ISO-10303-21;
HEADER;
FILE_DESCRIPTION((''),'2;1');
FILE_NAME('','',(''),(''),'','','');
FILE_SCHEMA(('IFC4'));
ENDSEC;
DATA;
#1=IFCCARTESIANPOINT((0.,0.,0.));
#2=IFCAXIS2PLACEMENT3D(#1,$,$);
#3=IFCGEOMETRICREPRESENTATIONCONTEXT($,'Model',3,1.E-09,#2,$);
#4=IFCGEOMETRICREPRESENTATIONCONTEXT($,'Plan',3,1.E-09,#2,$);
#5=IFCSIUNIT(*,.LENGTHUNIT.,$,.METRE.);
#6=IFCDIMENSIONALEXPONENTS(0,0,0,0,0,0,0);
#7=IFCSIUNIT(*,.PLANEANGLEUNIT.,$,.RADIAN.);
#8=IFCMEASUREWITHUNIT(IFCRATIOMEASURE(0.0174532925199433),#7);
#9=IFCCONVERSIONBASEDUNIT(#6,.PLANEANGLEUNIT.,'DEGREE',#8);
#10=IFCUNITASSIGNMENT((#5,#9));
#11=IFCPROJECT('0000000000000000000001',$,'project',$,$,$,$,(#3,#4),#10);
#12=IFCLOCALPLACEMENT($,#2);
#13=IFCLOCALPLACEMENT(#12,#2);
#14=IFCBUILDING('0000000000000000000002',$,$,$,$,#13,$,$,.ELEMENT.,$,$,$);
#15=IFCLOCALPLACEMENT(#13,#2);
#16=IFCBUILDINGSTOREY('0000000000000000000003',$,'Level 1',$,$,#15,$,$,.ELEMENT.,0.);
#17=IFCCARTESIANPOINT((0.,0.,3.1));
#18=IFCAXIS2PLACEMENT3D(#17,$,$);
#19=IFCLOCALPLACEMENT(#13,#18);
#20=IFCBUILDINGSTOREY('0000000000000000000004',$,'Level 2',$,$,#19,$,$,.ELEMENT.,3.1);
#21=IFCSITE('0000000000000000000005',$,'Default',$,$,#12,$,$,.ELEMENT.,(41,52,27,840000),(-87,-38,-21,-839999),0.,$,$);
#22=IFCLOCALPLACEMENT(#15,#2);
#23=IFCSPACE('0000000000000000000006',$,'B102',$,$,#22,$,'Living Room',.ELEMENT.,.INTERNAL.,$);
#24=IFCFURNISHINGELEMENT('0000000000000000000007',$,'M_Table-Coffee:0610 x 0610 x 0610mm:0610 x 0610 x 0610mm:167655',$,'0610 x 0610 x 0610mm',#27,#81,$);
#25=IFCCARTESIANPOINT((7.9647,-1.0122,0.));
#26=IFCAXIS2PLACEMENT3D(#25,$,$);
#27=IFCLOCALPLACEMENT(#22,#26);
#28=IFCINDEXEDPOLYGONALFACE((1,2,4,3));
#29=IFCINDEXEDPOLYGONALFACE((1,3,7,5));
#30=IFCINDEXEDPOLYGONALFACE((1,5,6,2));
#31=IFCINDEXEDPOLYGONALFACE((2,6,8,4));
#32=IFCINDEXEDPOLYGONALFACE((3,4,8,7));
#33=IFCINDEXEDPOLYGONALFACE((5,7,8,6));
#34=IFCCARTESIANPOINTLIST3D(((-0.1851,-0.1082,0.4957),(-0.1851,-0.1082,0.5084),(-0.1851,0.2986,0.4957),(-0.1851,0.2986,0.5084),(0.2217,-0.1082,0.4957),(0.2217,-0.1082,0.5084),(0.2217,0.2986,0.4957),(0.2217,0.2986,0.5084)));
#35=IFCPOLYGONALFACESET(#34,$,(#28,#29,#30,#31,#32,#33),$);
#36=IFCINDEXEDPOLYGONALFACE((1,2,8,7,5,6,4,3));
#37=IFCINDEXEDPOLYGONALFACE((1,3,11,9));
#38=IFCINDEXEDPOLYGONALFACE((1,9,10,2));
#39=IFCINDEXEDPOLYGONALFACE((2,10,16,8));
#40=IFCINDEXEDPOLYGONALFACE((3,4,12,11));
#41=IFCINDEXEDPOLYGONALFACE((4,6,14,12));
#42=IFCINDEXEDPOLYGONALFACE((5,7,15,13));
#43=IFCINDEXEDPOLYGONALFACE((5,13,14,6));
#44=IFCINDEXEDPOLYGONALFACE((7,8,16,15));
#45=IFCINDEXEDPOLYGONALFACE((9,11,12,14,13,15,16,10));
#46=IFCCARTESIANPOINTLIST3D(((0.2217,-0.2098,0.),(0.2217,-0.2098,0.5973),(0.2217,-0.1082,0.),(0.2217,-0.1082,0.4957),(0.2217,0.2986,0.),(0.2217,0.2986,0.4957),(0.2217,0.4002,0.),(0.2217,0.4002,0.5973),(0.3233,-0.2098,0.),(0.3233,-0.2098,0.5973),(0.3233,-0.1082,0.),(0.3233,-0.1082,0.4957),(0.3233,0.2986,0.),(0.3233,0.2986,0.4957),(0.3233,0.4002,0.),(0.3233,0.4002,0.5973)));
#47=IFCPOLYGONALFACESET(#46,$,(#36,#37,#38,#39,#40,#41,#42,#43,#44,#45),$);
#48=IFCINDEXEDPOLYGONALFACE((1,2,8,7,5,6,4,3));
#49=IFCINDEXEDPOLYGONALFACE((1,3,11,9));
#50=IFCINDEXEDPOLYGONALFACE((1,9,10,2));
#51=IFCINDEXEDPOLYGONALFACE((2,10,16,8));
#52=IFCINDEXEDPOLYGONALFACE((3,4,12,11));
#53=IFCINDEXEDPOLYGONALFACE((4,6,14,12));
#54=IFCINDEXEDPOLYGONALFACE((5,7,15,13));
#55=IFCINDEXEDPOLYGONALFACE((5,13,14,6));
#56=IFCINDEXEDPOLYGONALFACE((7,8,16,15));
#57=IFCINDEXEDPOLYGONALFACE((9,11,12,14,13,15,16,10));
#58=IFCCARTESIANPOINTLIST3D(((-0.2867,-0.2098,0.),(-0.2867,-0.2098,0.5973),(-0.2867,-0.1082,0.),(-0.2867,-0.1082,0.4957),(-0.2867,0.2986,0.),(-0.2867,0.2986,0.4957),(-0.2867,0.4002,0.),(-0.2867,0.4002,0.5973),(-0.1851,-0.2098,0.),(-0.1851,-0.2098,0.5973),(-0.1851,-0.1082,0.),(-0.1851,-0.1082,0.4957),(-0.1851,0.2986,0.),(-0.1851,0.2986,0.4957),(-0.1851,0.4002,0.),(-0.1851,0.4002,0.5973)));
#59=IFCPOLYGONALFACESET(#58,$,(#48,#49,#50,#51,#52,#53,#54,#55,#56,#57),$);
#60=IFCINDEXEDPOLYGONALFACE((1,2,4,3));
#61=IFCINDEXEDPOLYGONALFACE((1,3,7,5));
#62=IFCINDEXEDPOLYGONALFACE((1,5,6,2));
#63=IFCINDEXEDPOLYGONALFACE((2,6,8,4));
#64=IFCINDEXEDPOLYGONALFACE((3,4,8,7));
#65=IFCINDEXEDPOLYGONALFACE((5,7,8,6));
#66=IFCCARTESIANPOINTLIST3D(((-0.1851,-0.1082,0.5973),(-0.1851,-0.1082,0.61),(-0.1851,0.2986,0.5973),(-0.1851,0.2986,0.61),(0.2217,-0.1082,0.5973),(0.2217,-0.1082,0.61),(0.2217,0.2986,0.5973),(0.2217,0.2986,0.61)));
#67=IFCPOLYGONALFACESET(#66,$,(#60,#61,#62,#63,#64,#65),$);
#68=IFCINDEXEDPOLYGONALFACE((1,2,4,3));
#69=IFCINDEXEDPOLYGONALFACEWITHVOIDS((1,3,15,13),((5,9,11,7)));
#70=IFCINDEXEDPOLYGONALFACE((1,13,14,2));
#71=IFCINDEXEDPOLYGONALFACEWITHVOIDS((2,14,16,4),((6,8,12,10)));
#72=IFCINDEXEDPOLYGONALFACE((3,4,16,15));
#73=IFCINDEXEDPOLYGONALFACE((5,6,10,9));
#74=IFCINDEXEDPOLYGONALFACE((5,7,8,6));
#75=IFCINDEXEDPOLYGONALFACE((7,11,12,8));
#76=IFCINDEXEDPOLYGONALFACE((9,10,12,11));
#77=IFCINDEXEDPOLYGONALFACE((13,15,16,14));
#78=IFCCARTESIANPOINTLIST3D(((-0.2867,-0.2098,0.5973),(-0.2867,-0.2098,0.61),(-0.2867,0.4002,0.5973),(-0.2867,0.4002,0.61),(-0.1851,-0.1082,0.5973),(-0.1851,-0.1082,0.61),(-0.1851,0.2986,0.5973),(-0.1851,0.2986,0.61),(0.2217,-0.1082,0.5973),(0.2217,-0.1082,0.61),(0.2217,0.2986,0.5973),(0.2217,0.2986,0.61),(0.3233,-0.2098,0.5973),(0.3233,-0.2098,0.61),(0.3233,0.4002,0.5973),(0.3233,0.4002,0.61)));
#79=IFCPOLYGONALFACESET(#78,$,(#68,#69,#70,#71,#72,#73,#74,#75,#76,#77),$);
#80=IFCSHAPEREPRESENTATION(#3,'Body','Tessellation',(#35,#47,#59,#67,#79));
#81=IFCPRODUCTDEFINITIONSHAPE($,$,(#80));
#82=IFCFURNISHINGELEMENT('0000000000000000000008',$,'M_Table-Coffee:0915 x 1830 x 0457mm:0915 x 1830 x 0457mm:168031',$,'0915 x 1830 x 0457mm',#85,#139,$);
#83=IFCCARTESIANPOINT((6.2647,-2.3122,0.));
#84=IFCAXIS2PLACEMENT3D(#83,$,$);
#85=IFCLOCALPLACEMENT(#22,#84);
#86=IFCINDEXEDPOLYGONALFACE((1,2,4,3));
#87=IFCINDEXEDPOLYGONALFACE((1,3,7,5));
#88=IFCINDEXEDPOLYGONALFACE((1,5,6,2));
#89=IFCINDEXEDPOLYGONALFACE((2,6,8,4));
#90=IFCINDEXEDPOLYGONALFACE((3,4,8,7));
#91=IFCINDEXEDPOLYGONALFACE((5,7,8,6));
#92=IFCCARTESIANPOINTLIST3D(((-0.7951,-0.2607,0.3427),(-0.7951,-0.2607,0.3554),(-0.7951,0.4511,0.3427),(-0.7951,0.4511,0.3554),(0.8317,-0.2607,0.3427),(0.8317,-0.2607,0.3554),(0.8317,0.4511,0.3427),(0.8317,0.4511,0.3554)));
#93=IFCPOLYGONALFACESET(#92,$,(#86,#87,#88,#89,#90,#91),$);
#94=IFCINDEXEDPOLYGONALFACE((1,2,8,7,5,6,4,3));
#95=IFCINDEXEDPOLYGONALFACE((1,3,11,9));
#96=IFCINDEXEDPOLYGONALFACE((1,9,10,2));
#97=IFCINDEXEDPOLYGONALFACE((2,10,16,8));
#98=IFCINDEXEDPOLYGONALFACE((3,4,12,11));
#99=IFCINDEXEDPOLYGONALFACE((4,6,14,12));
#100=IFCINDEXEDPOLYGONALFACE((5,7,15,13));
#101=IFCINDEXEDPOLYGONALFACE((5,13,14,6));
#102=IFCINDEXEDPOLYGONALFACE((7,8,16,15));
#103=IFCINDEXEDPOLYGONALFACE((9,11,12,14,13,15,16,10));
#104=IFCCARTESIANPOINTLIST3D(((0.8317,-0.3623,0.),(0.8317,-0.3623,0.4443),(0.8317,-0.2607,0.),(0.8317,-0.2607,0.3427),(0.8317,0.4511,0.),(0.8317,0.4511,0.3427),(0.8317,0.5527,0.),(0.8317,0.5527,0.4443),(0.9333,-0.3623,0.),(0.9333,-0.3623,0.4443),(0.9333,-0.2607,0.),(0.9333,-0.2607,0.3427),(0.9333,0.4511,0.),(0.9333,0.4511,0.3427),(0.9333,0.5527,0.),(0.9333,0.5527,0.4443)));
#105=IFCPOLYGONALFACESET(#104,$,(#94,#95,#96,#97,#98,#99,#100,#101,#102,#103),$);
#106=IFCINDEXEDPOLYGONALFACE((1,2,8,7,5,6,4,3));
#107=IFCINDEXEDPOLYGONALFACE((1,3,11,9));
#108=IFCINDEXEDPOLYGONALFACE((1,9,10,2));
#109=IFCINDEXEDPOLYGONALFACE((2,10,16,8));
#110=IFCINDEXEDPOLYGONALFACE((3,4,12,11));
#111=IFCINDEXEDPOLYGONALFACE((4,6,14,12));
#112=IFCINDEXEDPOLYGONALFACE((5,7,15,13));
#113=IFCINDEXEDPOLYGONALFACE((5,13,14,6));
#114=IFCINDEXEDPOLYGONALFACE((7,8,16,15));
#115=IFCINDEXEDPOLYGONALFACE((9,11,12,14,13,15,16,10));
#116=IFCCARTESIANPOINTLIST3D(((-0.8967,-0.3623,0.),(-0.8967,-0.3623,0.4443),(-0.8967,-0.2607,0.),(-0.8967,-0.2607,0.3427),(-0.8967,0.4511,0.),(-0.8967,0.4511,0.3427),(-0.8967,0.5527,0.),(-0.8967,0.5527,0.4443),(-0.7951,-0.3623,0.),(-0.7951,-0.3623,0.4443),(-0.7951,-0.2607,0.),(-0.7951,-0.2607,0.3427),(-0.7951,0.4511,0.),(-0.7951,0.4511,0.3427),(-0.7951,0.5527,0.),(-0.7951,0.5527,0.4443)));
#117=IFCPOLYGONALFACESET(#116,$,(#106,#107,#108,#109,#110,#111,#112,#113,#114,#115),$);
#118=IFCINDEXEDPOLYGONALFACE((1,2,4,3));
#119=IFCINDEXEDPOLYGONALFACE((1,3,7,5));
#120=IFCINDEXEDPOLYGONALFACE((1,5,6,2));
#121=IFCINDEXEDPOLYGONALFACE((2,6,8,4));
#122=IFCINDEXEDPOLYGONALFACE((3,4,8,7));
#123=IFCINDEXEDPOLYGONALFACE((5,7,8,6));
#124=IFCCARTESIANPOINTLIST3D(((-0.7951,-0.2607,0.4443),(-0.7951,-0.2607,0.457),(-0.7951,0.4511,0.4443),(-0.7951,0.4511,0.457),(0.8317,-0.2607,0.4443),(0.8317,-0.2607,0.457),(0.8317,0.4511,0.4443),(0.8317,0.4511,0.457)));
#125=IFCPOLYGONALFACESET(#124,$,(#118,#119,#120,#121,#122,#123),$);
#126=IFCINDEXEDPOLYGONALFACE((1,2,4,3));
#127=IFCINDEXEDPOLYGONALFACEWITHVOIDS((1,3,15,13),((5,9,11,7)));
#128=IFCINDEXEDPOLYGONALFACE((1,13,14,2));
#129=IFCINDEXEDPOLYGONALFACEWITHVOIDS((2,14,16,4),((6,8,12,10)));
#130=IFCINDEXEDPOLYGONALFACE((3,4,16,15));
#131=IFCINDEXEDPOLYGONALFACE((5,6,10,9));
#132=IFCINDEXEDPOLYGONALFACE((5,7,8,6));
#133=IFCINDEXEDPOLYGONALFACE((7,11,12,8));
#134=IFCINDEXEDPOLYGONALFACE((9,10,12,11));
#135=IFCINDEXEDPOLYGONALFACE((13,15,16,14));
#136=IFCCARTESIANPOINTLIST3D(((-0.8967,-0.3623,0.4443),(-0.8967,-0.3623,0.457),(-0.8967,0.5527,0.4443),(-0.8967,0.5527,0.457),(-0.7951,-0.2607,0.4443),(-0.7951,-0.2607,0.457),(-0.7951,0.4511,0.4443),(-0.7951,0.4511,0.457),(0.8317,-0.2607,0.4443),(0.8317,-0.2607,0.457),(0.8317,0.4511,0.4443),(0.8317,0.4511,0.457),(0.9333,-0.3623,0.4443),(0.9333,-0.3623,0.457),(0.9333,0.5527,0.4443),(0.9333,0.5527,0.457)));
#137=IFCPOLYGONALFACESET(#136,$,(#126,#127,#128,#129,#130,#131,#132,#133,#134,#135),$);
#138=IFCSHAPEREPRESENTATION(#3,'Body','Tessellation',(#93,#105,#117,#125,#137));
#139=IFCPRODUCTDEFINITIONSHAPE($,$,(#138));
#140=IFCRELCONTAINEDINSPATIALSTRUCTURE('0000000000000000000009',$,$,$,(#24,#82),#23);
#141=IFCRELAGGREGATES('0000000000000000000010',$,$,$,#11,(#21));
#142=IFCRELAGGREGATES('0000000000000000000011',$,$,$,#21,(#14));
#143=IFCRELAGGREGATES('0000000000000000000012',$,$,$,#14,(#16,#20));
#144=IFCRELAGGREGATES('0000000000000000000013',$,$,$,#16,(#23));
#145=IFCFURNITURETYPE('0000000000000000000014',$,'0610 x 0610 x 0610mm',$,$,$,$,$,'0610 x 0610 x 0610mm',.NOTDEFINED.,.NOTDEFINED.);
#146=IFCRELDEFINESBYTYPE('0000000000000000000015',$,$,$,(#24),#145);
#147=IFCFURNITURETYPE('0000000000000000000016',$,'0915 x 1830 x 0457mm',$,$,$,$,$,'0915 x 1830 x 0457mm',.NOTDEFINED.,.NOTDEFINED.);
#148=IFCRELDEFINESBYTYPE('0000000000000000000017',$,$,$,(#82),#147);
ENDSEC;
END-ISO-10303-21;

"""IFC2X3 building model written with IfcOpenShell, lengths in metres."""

from ifc_helpers import new_model, entity, si_unit, converted_unit, frame, origin, origin_2d_with_axis, place, context, project, spatial, polyline, rectangle, outline, extrude, source, transform, mapped, type_object, type_shapes, element, save


model = new_model("IFC2X3")

# Units and contexts
model_context = context("Model", 3, precision=1e-09, world=origin())
plan_context = context("Plan", 3, precision=1e-09, world=origin())
ifc_project = project(units=[si_unit("LENGTHUNIT", "METRE"), converted_unit("PLANEANGLEUNIT", "DEGREE", entity("IfcRatioMeasure", 0.0174532925199433), si_unit("PLANEANGLEUNIT", "RADIAN"), dimensions=[0, 0, 0, 0, 0, 0, 0])], contexts=[model_context, plan_context])

# Site, building, storey
site_placement = place(None, origin())
site = spatial("IfcSite", under=ifc_project, at=site_placement, Name="Default", CompositionType="ELEMENT", RefLatitude=(41, 52, 27, 840000), RefLongitude=(-87, -38, -21, -839999), RefElevation=0.0)
building_placement = place(site_placement, origin())
building = spatial("IfcBuilding", under=site, at=building_placement, CompositionType="ELEMENT")
storey_1_placement = place(building_placement, origin())
storey_1 = spatial("IfcBuildingStorey", under=building, at=storey_1_placement, Name="Level 1", CompositionType="ELEMENT", Elevation=0.0)

# Shared definitions
storey_2_placement = place(building_placement, frame((0.0, 0.0, 3.1)))
storey_2 = spatial("IfcBuildingStorey", under=building, at=storey_2_placement, Name="Level 2", CompositionType="ELEMENT", Elevation=3.1)

# Shared definitions
space_1_placement = place(storey_1_placement, origin())
space_1 = spatial("IfcSpace", under=storey_1, at=space_1_placement, Name="B102", LongName="Living Room", CompositionType="ELEMENT", InteriorOrExteriorSpace="INTERNAL")

# Furnishing elements
furniture_type_1 = type_object("IfcFurnitureType", Name="0610 x 0610 x 0610mm", ElementType="0610 x 0610 x 0610mm", AssemblyPlace="NOTDEFINED")
shared_shape_1 = source(origin(), model_context, "Body", "SweptSolid", [
    extrude(rectangle(XDim=0.4068, YDim=0.4068, at=origin_2d_with_axis()), frame((0.0183, 0.0952, 0.4957), z_axis=(0.0, 0.0, 1.0), x_axis=(-1.0, 0.0, 0.0)), (0.0, 0.0, 1.0), 0.0127),
    extrude(outline(polyline([(-0.2732, -0.305), (0.324, -0.305), (0.324, 0.305), (-0.2732, 0.305), (-0.2732, 0.2034), (0.2225, 0.2034), (0.2225, -0.2034), (-0.2732, -0.2034), (-0.2732, -0.305)])), frame((0.2217, 0.0952, 0.2732), z_axis=(1.0, 0.0, 0.0), x_axis=(0.0, 0.0, 1.0)), (0.0, 0.0, 1.0), 0.1016),
    extrude(outline(polyline([(-0.305, -0.3241), (0.305, -0.3241), (0.305, 0.2733), (0.2034, 0.2733), (0.2034, -0.2224), (-0.2034, -0.2224), (-0.2034, 0.2733), (-0.305, 0.2733), (-0.305, -0.3241)])), frame((-0.2867, 0.0952, 0.2733), z_axis=(1.0, 0.0, 0.0), x_axis=(0.0, -1.0, 0.0)), (0.0, 0.0, 1.0), 0.1016),
    extrude(rectangle(XDim=0.4068, YDim=0.4068, at=origin_2d_with_axis()), frame((0.0183, 0.0952, 0.5973), z_axis=(0.0, 0.0, 1.0), x_axis=(-1.0, 0.0, 0.0)), (0.0, 0.0, 1.0), 0.0127),
    extrude(outline(polyline([(-0.305, -0.305), (0.305, -0.305), (0.305, 0.305), (-0.305, 0.305), (-0.305, -0.305)]), holes=[polyline([(-0.2034, -0.2034), (-0.2034, 0.2034), (0.2034, 0.2034), (0.2034, -0.2034), (-0.2034, -0.2034)])]), frame((0.0183, 0.0952, 0.5973), z_axis=(0.0, 0.0, 1.0), x_axis=(-1.0, 0.0, 0.0)), (0.0, 0.0, 1.0), 0.0127),
])
type_shapes(furniture_type_1, [shared_shape_1])
for number, where, name in (
    (1, (7.9647, -1.0122, 0.0), "M_Table-Coffee:0610 x 0610 x 0610mm:0610 x 0610 x 0610mm:167655"),
):
    element("IfcFurnishingElement", number, at=place(space_1_placement, frame(where)), inside=space_1, type_object=furniture_type_1, Name=name, ObjectType="0610 x 0610 x 0610mm", context=model_context, shape_type="MappedRepresentation", body=[
        mapped(shared_shape_1, transform((0.0, 0.0, 0.0), scale=1.0)),
    ])
furniture_type_2 = type_object("IfcFurnitureType", Name="0915 x 1830 x 0457mm", ElementType="0915 x 1830 x 0457mm", AssemblyPlace="NOTDEFINED")
shared_shape_2 = source(origin(), model_context, "Body", "SweptSolid", [
    extrude(rectangle(XDim=1.6268, YDim=0.7118, at=origin_2d_with_axis()), frame((0.0183, 0.0952, 0.3427), z_axis=(0.0, 0.0, 1.0), x_axis=(-1.0, 0.0, 0.0)), (0.0, 0.0, 1.0), 0.0127),
    extrude(outline(polyline([(-0.1967, -0.4575), (0.2475, -0.4575), (0.2475, 0.4575), (-0.1967, 0.4575), (-0.1967, 0.3559), (0.146, 0.3559), (0.146, -0.3559), (-0.1967, -0.3559), (-0.1967, -0.4575)])), frame((0.8317, 0.0952, 0.1967), z_axis=(1.0, 0.0, 0.0), x_axis=(0.0, 0.0, 1.0)), (0.0, 0.0, 1.0), 0.1016),
    extrude(outline(polyline([(-0.4575, -0.2476), (0.4575, -0.2476), (0.4575, 0.1968), (0.3559, 0.1968), (0.3559, -0.1459), (-0.3559, -0.1459), (-0.3559, 0.1968), (-0.4575, 0.1968), (-0.4575, -0.2476)])), frame((-0.8967, 0.0952, 0.1968), z_axis=(1.0, 0.0, 0.0), x_axis=(0.0, -1.0, 0.0)), (0.0, 0.0, 1.0), 0.1016),
    extrude(rectangle(XDim=1.6268, YDim=0.7118, at=origin_2d_with_axis()), frame((0.0183, 0.0952, 0.4443), z_axis=(0.0, 0.0, 1.0), x_axis=(-1.0, 0.0, 0.0)), (0.0, 0.0, 1.0), 0.0127),
    extrude(outline(polyline([(-0.915, -0.4575), (0.915, -0.4575), (0.915, 0.4575), (-0.915, 0.4575), (-0.915, -0.4575)]), holes=[polyline([(-0.8134, -0.3559), (-0.8134, 0.3559), (0.8134, 0.3559), (0.8134, -0.3559), (-0.8134, -0.3559)])]), frame((0.0183, 0.0952, 0.4443), z_axis=(0.0, 0.0, 1.0), x_axis=(-1.0, 0.0, 0.0)), (0.0, 0.0, 1.0), 0.0127),
])
type_shapes(furniture_type_2, [shared_shape_2])
furnishing_1_placement = place(space_1_placement, frame((6.2647, -2.3122, 0.0)))
element("IfcFurnishingElement", 2, at=furnishing_1_placement, inside=space_1, type_object=furniture_type_2, Name="M_Table-Coffee:0915 x 1830 x 0457mm:0915 x 1830 x 0457mm:168031", ObjectType="0915 x 1830 x 0457mm", context=model_context, shape_type="MappedRepresentation", body=[
    mapped(shared_shape_2, transform((0.0, 0.0, 0.0), scale=1.0)),
])

save(model, "model.ifc")
